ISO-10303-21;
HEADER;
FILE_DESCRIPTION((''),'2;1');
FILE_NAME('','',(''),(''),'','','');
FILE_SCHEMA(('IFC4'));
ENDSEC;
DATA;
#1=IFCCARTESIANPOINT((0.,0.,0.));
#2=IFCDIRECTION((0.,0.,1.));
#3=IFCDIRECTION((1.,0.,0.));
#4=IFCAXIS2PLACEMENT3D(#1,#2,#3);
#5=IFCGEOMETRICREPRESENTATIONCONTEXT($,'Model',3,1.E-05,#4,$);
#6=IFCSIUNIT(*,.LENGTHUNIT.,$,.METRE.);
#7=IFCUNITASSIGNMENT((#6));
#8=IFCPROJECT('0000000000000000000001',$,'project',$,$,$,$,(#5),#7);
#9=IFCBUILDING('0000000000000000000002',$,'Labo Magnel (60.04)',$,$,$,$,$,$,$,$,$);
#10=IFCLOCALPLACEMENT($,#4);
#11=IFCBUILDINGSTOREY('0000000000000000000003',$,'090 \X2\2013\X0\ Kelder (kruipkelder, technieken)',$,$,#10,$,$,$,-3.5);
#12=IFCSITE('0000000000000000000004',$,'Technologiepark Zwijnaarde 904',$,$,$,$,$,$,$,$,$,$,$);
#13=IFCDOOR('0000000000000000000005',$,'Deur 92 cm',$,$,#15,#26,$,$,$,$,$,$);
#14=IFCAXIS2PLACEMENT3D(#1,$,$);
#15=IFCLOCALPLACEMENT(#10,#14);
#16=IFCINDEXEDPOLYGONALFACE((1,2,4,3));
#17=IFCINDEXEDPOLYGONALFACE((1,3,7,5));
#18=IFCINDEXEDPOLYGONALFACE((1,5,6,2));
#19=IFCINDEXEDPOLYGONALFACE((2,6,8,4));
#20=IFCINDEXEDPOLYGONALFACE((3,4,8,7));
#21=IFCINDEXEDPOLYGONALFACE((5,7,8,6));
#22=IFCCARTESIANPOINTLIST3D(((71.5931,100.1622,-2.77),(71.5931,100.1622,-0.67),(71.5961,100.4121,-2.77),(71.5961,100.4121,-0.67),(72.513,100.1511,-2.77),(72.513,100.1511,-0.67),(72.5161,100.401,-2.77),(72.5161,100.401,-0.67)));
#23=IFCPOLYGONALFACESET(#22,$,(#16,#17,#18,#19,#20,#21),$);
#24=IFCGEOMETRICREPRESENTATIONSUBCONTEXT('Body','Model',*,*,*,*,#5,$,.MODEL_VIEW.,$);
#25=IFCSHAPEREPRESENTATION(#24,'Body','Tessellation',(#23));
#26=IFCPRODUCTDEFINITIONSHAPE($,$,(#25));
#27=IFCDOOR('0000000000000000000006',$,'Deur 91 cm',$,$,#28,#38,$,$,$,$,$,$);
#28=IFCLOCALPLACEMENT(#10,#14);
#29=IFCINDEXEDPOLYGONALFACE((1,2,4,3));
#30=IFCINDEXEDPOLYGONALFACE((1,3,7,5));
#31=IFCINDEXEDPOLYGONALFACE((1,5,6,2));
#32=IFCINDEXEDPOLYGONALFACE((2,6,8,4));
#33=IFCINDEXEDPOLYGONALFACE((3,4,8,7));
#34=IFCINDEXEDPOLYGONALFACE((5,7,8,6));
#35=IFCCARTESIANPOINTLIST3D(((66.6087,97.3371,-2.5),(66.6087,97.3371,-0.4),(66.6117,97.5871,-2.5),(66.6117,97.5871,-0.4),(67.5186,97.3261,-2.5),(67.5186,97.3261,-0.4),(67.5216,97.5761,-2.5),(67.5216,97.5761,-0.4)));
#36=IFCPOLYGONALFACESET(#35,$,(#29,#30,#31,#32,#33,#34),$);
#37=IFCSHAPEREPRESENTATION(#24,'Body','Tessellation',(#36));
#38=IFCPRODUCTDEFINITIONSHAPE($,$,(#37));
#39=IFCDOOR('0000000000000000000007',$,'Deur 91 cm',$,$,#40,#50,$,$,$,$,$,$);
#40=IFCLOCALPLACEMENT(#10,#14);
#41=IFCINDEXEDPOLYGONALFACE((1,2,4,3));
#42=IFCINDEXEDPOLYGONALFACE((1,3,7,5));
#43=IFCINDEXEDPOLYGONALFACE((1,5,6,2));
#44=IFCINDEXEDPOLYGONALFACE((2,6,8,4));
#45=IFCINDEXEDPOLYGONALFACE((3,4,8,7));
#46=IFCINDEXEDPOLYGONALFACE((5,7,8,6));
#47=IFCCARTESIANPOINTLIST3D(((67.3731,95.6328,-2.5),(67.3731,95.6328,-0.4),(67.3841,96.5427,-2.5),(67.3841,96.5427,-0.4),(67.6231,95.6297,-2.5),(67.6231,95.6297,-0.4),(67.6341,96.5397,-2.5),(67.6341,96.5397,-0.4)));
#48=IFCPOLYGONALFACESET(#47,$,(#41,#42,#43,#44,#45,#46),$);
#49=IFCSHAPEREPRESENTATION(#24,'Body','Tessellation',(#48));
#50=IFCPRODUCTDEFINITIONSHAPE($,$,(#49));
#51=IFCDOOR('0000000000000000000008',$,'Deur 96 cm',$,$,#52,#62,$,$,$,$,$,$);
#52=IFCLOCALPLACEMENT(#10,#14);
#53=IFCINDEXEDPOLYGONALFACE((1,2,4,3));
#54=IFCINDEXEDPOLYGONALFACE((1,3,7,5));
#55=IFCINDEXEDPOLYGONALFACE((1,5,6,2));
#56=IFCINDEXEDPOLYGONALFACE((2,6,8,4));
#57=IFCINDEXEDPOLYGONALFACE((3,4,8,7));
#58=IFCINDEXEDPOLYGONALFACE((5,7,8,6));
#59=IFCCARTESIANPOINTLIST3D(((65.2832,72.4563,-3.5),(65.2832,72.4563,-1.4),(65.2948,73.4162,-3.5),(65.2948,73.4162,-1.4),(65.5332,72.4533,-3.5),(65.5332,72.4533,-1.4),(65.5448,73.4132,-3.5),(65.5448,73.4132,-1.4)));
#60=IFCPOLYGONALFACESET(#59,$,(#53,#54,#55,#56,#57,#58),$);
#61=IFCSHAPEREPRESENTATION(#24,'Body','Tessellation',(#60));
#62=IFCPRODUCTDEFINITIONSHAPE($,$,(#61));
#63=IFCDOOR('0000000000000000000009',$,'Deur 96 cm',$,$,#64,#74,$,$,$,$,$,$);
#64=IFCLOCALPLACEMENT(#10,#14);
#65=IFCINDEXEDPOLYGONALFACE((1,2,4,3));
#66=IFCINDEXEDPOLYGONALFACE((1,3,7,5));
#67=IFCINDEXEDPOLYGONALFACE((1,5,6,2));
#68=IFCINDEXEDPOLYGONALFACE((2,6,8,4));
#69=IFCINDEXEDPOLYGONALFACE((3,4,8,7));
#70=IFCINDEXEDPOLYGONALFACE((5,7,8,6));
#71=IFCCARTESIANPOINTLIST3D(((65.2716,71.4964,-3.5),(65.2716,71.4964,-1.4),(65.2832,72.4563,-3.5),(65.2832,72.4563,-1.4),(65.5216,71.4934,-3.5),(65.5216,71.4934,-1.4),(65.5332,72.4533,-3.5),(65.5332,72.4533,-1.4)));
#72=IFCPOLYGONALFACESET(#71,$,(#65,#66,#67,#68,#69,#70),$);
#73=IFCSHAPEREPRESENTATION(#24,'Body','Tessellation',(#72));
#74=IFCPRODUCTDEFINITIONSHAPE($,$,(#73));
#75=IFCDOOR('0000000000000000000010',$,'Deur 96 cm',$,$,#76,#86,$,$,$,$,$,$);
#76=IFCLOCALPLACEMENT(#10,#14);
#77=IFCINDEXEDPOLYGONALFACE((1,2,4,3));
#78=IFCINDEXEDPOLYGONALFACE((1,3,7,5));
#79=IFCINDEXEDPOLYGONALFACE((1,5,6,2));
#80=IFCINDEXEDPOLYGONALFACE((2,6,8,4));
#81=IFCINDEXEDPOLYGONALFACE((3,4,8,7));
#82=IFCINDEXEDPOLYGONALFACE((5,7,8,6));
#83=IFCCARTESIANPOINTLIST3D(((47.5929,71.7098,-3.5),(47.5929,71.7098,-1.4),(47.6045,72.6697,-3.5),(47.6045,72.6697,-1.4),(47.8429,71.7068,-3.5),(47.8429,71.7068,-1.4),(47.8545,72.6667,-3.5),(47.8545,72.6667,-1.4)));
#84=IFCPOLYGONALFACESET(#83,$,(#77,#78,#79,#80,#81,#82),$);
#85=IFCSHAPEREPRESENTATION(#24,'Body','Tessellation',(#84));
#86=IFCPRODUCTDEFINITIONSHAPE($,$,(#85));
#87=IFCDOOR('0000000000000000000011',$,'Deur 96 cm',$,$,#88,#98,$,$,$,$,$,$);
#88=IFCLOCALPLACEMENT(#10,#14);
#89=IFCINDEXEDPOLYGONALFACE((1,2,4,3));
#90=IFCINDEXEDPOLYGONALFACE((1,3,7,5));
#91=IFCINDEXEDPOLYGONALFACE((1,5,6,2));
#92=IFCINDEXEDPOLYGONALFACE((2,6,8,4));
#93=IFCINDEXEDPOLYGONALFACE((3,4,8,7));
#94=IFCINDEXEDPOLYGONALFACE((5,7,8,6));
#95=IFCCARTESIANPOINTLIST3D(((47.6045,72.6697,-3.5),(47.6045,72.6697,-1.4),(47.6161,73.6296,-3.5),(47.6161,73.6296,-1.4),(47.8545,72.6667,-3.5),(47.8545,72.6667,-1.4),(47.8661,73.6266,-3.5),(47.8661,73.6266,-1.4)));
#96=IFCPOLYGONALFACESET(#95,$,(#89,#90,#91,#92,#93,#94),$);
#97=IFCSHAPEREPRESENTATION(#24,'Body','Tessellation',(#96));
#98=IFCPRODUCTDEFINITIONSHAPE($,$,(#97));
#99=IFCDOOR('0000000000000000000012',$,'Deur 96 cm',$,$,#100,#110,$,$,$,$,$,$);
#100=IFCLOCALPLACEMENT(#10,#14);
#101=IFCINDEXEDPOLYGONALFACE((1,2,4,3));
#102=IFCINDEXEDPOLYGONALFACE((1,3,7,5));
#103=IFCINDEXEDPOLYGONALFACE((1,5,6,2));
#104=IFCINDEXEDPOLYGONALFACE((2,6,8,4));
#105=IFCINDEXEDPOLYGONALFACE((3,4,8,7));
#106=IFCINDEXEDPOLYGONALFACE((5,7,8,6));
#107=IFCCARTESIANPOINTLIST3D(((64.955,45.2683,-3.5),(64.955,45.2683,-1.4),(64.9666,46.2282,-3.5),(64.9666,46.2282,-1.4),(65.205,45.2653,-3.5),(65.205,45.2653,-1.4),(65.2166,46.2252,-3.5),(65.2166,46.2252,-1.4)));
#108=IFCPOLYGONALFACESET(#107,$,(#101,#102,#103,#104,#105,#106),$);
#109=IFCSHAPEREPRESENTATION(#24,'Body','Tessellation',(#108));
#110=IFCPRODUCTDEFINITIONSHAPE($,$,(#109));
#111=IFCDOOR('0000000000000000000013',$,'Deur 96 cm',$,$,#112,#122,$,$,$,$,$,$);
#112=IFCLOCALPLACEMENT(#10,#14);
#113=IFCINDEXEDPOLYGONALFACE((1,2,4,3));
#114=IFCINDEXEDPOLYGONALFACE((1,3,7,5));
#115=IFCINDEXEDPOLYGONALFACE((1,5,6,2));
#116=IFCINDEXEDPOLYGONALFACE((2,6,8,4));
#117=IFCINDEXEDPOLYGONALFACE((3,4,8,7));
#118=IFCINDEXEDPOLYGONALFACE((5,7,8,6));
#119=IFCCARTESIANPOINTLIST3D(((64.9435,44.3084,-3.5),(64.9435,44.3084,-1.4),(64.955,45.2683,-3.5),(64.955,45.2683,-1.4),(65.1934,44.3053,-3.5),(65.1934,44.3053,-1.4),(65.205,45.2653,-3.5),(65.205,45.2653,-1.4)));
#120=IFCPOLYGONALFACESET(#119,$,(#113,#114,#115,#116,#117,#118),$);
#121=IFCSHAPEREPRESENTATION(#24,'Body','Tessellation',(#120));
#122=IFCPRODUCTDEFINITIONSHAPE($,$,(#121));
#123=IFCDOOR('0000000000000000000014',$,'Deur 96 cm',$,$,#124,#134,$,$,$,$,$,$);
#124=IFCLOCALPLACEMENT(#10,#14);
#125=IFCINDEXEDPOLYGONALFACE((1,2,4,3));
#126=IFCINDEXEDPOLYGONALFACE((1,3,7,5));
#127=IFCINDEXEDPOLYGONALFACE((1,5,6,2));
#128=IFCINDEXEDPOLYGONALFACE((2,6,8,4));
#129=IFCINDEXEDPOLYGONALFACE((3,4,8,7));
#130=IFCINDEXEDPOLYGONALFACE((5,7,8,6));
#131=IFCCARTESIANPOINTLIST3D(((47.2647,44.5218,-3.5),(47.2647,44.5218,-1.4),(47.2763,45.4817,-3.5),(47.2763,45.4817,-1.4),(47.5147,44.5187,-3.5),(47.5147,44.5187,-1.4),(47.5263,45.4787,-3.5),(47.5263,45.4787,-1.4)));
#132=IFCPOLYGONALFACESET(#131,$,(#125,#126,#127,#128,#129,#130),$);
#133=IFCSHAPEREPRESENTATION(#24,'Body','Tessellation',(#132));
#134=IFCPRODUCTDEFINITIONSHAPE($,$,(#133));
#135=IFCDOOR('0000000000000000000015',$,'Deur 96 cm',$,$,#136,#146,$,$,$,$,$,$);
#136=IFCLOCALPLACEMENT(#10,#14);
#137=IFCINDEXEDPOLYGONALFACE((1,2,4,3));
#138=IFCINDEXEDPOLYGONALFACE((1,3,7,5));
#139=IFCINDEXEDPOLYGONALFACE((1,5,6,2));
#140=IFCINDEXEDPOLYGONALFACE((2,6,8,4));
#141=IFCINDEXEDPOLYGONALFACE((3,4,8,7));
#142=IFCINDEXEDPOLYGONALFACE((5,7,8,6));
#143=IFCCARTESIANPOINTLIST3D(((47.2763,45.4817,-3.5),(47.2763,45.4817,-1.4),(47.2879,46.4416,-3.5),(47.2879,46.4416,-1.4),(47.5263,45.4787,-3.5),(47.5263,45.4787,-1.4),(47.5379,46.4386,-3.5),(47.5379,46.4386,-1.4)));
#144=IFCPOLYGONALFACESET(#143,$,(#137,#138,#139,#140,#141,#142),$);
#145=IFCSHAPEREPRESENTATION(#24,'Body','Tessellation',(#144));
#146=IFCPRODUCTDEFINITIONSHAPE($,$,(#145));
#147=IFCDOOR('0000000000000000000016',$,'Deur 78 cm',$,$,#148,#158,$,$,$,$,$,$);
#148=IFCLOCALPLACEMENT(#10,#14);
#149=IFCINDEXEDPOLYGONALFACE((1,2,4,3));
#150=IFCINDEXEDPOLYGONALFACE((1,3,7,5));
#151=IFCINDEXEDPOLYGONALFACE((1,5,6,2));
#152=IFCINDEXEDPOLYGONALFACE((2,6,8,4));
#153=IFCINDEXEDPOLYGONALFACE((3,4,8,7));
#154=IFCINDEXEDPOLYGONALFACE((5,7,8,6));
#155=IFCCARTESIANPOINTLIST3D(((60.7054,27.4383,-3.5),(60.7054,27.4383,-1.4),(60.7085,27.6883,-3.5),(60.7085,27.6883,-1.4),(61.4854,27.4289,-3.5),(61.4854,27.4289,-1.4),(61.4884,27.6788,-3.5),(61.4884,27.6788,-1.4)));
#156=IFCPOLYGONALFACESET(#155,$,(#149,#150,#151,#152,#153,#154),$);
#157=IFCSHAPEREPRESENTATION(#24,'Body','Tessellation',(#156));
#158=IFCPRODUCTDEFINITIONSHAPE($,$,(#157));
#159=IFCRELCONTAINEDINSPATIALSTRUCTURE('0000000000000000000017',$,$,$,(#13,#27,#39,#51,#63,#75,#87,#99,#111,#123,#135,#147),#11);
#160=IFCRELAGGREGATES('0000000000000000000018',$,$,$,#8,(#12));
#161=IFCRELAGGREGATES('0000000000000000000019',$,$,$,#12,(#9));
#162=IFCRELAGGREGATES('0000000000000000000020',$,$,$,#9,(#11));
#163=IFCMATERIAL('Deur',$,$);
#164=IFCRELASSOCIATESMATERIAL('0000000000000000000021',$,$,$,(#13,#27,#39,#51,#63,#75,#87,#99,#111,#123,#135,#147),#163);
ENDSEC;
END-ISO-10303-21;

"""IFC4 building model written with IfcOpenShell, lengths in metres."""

from ifc_helpers import new_model, si_unit, frame, origin, origin_with_axes, place, context, subcontext, project, spatial, polyline, outline, extrude, material, element, save


model = new_model("IFC4")

# Units and contexts
model_context = context("Model", 3, precision=1e-05, world=origin_with_axes())
body_context = subcontext(model_context, "Body", "Model", "MODEL_VIEW")
ifc_project = project(units=[si_unit("LENGTHUNIT", "METRE")], contexts=[model_context])

# Site, building, storey
site = spatial("IfcSite", under=ifc_project, Name="Technologiepark Zwijnaarde 904")
building = spatial("IfcBuilding", under=site, Name="Labo Magnel (60.04)")
storey_placement = place(None, origin_with_axes())
storey = spatial("IfcBuildingStorey", under=building, at=storey_placement, Name="090 – Kelder (kruipkelder, technieken)", Elevation=-3.5)

# Doors
ifc_material_1 = material(Name="Deur")
door_1_placement = place(storey_placement, frame((72.5146, 100.276, -2.77), z_axis=(0.0, 0.0, 1.0), x_axis=(-0.999927, 0.01207, 0.0)))
element("IfcDoor", 1, at=door_1_placement, inside=storey, material=ifc_material_1, Name="Deur 92 cm", context=body_context, shape_type="SweptSolid", body=[
    extrude(outline(polyline([(0.0, -0.125), (0.92, -0.125), (0.92, 0.125), (0.0, 0.125), (0.0, -0.125)])), origin(), (0.0, 0.0, 1.0), 2.1),
])
for number, where, z_axis, x_axis, name in (
    (2, (67.5201, 97.4511, -2.5), (0.0, 0.0, 1.0), (-0.999927, 0.01207, 0.0), "Deur 91 cm"),
    (3, (67.4981, 95.6313, -2.5), (0.0, 0.0, 1.0), (0.01207, 0.999927, 0.0), "Deur 91 cm"),
):
    element("IfcDoor", number, at=place(storey_placement, frame(where, z_axis=z_axis, x_axis=x_axis)), inside=storey, material=ifc_material_1, Name=name, context=body_context, shape_type="SweptSolid", body=[
        extrude(outline(polyline([(0.0, -0.125), (0.91, -0.125), (0.91, 0.125), (0.0, 0.125), (0.0, -0.125)])), origin(), (0.0, 0.0, 1.0), 2.1),
    ])
for number, where, z_axis, x_axis, name in (
    (4, (65.4198, 73.4147, -3.5), (0.0, 0.0, 1.0), (-0.01207, -0.999927, 0.0), "Deur 96 cm"),
    (5, (65.3966, 71.4949, -3.5), (0.0, 0.0, 1.0), (0.01207, 0.999927, 0.0), "Deur 96 cm"),
    (6, (47.7179, 71.7083, -3.5), (0.0, 0.0, 1.0), (0.01207, 0.999927, 0.0), "Deur 96 cm"),
    (7, (47.7411, 73.6281, -3.5), (0.0, 0.0, 1.0), (-0.01207, -0.999927, 0.0), "Deur 96 cm"),
    (8, (65.0916, 46.2267, -3.5), (0.0, 0.0, 1.0), (-0.01207, -0.999927, 0.0), "Deur 96 cm"),
    (9, (65.0684, 44.3068, -3.5), (0.0, 0.0, 1.0), (0.01207, 0.999927, 0.0), "Deur 96 cm"),
    (10, (47.3897, 44.5202, -3.5), (0.0, 0.0, 1.0), (0.01207, 0.999927, 0.0), "Deur 96 cm"),
    (11, (47.4129, 46.4401, -3.5), (0.0, 0.0, 1.0), (-0.01207, -0.999927, 0.0), "Deur 96 cm"),
):
    element("IfcDoor", number, at=place(storey_placement, frame(where, z_axis=z_axis, x_axis=x_axis)), inside=storey, material=ifc_material_1, Name=name, context=body_context, shape_type="SweptSolid", body=[
        extrude(outline(polyline([(0.0, -0.125), (0.96, -0.125), (0.96, 0.125), (0.0, 0.125), (0.0, -0.125)])), origin(), (0.0, 0.0, 1.0), 2.1),
    ])
door_2_placement = place(storey_placement, frame((61.4869, 27.5539, -3.5), z_axis=(0.0, 0.0, 1.0), x_axis=(-0.999927, 0.01207, 0.0)))
element("IfcDoor", 12, at=door_2_placement, inside=storey, material=ifc_material_1, Name="Deur 78 cm", context=body_context, shape_type="SweptSolid", body=[
    extrude(outline(polyline([(0.0, -0.125), (0.78, -0.125), (0.78, 0.125), (0.0, 0.125), (0.0, -0.125)])), origin(), (0.0, 0.0, 1.0), 2.1),
])

save(model, "model.ifc")
